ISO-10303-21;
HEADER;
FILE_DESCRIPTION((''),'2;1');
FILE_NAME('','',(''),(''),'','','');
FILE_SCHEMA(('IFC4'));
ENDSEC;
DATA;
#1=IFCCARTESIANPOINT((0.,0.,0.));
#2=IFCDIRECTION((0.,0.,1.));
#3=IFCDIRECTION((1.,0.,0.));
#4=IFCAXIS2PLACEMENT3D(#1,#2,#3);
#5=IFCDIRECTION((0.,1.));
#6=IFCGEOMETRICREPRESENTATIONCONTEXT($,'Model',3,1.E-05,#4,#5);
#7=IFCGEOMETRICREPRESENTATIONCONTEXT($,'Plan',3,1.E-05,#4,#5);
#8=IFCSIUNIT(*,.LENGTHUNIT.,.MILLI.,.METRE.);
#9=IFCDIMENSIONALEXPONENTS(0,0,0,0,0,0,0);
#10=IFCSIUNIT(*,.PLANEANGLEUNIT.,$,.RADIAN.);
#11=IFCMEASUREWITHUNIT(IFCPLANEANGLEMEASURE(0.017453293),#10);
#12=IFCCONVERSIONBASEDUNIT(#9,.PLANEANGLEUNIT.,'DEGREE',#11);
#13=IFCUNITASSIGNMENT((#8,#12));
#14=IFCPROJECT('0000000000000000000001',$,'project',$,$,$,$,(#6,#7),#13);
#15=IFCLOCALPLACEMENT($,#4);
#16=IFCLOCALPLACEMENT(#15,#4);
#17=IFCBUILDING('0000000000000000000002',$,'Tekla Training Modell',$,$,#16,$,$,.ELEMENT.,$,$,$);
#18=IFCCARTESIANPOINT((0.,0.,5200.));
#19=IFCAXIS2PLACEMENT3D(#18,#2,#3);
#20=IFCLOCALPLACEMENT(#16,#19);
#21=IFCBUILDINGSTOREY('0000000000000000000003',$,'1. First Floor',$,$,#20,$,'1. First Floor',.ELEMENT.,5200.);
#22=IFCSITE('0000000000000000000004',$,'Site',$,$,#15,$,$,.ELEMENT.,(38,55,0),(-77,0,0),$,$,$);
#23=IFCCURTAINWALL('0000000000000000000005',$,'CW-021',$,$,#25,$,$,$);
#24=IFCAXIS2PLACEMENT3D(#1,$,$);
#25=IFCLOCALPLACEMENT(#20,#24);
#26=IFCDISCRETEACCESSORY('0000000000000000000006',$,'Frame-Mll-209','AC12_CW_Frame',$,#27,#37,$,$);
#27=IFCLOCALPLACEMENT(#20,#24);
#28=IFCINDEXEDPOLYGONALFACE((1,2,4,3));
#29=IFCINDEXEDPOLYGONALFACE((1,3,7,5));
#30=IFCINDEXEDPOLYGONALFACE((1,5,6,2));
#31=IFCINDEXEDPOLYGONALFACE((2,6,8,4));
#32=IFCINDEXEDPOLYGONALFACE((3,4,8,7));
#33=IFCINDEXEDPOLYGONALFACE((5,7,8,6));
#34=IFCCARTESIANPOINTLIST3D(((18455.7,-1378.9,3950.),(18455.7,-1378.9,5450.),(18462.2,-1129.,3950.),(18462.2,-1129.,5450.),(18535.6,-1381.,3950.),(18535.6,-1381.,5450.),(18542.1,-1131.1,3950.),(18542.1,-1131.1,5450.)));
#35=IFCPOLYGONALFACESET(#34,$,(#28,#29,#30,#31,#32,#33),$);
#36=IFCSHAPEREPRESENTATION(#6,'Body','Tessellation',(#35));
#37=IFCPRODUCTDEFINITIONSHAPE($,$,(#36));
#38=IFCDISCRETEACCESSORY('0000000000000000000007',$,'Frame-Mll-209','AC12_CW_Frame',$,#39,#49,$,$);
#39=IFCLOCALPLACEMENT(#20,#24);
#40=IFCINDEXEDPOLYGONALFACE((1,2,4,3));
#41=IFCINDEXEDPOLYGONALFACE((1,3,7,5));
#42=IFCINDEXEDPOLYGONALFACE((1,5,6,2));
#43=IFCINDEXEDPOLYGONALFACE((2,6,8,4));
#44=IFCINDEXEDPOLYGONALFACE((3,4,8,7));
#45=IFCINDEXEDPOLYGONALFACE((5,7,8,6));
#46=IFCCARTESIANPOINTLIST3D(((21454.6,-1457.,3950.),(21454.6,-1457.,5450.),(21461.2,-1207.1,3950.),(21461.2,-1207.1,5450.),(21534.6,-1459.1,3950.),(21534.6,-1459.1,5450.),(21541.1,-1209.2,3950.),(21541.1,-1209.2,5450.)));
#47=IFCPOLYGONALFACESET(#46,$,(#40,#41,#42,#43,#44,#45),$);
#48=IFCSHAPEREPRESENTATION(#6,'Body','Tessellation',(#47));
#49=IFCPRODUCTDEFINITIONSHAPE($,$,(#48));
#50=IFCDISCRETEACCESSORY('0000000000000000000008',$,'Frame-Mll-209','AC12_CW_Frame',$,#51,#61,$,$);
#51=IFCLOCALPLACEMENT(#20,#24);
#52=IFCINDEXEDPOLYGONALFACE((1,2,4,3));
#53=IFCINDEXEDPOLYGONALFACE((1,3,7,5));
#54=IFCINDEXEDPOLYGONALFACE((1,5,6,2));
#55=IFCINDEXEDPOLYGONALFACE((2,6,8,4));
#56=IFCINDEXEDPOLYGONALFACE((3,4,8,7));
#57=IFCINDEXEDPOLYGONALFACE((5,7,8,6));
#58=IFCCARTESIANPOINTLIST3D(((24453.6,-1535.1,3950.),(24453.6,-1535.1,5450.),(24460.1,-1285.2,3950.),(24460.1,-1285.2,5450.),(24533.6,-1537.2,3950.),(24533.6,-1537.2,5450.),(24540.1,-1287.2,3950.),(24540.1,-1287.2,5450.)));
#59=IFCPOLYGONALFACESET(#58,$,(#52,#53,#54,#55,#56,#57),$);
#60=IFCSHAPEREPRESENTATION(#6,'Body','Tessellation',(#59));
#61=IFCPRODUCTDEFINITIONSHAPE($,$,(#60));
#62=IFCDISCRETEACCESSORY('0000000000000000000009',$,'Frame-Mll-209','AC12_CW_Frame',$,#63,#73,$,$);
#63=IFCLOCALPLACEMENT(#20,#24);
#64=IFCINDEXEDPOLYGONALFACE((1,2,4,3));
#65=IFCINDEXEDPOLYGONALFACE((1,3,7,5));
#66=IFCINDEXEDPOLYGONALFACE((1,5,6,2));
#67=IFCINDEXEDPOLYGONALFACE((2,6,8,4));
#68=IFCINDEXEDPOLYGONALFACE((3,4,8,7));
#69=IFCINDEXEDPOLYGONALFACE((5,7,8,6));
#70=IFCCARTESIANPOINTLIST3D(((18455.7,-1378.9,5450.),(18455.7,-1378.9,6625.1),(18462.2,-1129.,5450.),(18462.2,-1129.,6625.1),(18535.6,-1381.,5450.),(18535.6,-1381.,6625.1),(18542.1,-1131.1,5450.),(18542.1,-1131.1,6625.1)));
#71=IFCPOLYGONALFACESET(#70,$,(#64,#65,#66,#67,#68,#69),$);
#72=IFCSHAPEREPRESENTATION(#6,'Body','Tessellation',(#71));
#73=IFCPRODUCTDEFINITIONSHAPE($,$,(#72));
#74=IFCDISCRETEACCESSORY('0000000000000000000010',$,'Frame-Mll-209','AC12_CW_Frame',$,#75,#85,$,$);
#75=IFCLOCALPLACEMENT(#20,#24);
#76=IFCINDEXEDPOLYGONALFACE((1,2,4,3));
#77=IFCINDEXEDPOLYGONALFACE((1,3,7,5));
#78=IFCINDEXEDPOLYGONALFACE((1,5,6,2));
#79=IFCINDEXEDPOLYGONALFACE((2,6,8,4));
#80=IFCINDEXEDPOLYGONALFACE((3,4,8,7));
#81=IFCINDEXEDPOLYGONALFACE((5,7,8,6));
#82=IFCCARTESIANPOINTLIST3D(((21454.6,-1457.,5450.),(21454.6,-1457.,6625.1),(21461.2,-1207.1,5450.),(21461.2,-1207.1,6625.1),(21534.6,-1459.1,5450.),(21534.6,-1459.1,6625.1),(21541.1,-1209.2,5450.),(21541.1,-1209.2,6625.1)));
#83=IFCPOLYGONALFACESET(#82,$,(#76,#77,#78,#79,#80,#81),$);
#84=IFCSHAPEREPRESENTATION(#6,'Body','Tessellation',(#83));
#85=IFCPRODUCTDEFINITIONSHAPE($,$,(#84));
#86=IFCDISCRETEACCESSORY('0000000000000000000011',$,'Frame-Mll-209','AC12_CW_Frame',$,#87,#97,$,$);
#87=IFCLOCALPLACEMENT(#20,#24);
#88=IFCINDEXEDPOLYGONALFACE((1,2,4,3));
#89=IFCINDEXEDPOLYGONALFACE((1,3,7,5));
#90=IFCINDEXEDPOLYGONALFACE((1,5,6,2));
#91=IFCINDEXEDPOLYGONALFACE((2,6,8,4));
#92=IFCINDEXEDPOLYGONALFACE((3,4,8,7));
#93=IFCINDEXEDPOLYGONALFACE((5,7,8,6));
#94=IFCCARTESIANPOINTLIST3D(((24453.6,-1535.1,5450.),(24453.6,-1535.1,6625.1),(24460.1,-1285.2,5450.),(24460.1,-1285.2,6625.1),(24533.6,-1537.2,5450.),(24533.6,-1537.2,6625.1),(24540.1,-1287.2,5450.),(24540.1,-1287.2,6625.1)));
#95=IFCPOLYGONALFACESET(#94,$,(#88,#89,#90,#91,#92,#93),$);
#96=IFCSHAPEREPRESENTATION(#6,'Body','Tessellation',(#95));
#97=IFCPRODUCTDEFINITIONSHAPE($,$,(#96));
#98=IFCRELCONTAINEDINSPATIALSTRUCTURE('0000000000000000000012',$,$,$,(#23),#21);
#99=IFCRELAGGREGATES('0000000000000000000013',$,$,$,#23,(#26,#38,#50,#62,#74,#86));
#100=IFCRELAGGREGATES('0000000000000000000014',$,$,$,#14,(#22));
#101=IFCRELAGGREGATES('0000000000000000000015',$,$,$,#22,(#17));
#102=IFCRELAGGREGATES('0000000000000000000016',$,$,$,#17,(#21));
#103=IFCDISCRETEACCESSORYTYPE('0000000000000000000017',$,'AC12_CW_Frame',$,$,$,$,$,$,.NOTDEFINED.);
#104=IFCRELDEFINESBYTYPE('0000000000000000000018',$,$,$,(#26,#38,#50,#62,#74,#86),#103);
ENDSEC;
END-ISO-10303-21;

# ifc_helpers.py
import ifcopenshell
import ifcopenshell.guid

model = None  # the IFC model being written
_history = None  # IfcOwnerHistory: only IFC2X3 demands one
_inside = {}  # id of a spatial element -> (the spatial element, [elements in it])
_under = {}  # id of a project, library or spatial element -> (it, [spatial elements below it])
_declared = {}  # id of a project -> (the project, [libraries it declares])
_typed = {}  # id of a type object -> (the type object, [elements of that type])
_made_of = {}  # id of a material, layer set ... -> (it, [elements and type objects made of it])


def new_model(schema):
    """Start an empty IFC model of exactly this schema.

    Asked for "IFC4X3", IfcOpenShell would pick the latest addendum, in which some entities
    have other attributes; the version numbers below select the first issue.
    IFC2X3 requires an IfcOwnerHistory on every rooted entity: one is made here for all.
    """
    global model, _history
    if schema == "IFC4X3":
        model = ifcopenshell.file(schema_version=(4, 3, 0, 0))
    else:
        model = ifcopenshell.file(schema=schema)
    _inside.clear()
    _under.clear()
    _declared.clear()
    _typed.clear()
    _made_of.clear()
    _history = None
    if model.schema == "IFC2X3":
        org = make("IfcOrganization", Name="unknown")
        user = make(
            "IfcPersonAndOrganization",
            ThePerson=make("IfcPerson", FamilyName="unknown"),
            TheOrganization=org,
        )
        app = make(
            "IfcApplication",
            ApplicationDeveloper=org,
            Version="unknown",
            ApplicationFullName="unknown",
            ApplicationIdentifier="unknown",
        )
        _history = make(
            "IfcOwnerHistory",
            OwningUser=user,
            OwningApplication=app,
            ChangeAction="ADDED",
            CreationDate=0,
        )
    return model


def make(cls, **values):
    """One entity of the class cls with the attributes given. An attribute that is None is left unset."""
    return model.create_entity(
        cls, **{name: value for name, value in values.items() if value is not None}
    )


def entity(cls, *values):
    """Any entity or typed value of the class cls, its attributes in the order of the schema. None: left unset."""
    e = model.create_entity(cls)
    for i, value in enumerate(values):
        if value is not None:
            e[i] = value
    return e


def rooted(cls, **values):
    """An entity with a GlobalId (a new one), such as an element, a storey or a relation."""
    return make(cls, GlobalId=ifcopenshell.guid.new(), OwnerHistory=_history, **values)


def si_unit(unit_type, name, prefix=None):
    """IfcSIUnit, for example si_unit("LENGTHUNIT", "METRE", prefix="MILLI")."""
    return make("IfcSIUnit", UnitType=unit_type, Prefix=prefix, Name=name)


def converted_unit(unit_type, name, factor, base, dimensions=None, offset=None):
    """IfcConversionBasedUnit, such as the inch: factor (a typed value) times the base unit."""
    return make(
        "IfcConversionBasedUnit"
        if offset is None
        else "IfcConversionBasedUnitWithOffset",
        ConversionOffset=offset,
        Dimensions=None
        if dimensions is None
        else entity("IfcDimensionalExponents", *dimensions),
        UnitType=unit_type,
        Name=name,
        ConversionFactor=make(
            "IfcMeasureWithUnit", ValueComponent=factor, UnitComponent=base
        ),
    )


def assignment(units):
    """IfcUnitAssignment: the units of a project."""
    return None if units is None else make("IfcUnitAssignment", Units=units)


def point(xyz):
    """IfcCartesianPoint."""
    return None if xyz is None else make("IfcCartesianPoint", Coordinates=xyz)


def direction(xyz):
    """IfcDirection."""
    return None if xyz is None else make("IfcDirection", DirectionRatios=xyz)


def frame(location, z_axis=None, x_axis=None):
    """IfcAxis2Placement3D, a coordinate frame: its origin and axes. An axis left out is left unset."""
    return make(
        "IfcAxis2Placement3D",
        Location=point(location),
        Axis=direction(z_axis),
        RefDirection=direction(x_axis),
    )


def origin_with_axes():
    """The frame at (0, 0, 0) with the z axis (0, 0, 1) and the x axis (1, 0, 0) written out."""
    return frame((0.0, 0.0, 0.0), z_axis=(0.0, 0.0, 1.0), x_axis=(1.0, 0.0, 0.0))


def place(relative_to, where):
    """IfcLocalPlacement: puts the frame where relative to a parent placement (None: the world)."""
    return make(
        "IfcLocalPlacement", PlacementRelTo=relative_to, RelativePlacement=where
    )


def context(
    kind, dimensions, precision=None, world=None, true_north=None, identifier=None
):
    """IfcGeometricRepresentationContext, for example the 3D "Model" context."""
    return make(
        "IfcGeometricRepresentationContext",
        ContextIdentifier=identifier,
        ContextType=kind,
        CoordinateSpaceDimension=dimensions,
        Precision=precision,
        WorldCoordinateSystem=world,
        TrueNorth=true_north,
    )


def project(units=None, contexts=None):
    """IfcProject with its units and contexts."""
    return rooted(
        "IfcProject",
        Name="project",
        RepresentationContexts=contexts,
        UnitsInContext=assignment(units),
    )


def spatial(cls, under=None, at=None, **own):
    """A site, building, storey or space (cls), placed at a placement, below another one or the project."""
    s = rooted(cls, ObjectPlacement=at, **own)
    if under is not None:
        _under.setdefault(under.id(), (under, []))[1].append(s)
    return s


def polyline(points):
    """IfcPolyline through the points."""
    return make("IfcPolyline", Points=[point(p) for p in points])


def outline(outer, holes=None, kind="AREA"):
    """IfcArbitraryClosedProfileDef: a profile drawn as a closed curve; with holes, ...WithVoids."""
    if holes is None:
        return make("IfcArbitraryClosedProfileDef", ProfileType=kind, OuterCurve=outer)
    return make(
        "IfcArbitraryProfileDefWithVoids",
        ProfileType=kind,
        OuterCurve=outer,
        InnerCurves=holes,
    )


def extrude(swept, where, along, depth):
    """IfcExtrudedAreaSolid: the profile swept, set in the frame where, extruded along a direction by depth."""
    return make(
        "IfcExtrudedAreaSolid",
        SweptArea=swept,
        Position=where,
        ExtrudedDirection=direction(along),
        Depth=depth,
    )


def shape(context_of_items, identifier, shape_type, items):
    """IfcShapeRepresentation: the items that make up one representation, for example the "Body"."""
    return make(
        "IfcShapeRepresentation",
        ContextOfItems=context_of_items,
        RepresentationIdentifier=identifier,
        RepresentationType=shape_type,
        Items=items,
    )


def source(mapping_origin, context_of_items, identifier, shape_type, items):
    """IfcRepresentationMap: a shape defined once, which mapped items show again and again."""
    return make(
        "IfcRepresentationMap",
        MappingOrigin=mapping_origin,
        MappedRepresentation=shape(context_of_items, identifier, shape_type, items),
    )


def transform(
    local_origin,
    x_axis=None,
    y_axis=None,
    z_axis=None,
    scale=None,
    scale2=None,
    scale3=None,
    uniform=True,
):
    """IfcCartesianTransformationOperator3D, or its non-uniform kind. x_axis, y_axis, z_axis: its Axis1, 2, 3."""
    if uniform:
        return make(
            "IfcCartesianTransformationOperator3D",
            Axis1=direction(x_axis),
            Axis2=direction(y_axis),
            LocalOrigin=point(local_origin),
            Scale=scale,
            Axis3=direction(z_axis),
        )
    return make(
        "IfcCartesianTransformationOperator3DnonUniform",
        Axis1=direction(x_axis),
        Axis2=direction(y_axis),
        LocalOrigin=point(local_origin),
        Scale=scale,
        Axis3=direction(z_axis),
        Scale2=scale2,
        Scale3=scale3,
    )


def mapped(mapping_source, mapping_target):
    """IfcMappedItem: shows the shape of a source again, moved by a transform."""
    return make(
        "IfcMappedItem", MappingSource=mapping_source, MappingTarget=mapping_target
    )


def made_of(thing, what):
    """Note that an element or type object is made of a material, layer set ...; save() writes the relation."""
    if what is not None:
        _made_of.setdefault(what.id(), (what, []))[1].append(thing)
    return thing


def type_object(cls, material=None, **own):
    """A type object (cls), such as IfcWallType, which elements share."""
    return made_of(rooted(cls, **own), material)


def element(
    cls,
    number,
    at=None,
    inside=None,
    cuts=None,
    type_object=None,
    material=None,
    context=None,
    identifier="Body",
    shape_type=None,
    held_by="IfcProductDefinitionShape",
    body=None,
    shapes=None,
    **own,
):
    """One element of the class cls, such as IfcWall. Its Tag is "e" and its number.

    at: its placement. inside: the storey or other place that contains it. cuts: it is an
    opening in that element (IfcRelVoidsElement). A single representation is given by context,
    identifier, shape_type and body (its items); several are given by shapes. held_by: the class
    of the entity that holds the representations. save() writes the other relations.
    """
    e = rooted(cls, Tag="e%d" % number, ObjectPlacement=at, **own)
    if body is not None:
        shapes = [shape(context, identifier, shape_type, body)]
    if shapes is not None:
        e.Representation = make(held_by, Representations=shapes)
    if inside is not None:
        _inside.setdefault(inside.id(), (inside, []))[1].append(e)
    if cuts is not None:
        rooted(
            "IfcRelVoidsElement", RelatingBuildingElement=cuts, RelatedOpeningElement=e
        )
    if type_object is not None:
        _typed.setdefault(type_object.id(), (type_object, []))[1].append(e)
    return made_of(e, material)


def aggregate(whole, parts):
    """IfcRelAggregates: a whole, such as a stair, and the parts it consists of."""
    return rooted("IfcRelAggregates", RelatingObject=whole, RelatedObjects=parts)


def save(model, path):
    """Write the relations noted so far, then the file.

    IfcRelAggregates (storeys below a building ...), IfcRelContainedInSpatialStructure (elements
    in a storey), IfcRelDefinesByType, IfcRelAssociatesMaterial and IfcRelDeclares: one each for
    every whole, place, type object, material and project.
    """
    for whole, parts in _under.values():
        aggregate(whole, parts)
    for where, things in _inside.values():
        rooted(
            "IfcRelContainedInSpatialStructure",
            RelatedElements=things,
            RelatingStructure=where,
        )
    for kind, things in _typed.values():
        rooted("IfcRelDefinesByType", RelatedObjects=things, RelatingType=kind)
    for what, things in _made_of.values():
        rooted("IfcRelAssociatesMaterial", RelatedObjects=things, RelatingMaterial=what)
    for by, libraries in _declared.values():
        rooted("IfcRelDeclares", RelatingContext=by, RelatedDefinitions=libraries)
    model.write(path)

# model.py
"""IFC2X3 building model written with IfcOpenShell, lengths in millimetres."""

from ifc_helpers import new_model, entity, si_unit, converted_unit, direction, frame, origin_with_axes, place, context, project, spatial, polyline, outline, extrude, source, transform, mapped, type_object, element, aggregate, save


model = new_model("IFC2X3")

# Units and contexts
model_context = context("Model", 3, precision=1e-05, world=origin_with_axes(), true_north=direction((0.0, 1.0)))
plan_context = context("Plan", 3, precision=1e-05, world=origin_with_axes(), true_north=direction((0.0, 1.0)))
ifc_project = project(units=[si_unit("LENGTHUNIT", "METRE", prefix="MILLI"), converted_unit("PLANEANGLEUNIT", "DEGREE", entity("IfcPlaneAngleMeasure", 0.017453293), si_unit("PLANEANGLEUNIT", "RADIAN"), dimensions=[0, 0, 0, 0, 0, 0, 0])], contexts=[model_context, plan_context])

# Site, building, storey
site_placement = place(None, origin_with_axes())
site = spatial("IfcSite", under=ifc_project, at=site_placement, Name="Site", CompositionType="ELEMENT", RefLatitude=(38, 55, 0), RefLongitude=(-77, 0, 0))
building_placement = place(site_placement, origin_with_axes())
building = spatial("IfcBuilding", under=site, at=building_placement, Name="Tekla Training Modell", CompositionType="ELEMENT")
storey_placement = place(building_placement, frame((0.0, 0.0, 5200.0), z_axis=(0.0, 0.0, 1.0), x_axis=(1.0, 0.0, 0.0)))
storey = spatial("IfcBuildingStorey", under=building, at=storey_placement, Name="1. First Floor", LongName="1. First Floor", CompositionType="ELEMENT", Elevation=5200.0)

# Curtain wall, discrete accessories
curtain_wall_placement = place(storey_placement, frame((9500.0, -1095.8, -550.0), z_axis=(0.0, 0.0, 1.0), x_axis=(0.999661, -0.026022, 0.0)))
curtain_wall = element("IfcCurtainWall", 1, at=curtain_wall_placement, inside=storey, Name="CW-021")
discrete_accessory_type = type_object("IfcDiscreteAccessoryType", Name="AC12_CW_Frame")
shared_shape_1 = source(origin_with_axes(), model_context, "Body", "SweptSolid", [
    extrude(outline(polyline([(0.0, 0.0), (250.0, 0.0), (250.0, -1500.0), (0.0, -1500.0), (0.0, 0.0)])), origin_with_axes(), (0.0, 0.0, 1.0), 80.0),
])
discrete_accessory_1_placement = place(storey_placement, frame((18462.2, -1129.0, 3950.0), z_axis=(0.999661, -0.026022, 0.0), x_axis=(-0.026022, -0.999661, 0.0)))
discrete_accessory_1 = element("IfcDiscreteAccessory", 2, at=discrete_accessory_1_placement, type_object=discrete_accessory_type, Name="Frame-Mll-209", Description="AC12_CW_Frame", context=model_context, shape_type="MappedRepresentation", body=[
    mapped(shared_shape_1, transform((0.0, 0.0, 0.0), scale=1.0)),
])
discrete_accessory_2_placement = place(storey_placement, frame((21461.2, -1207.1, 3950.0), z_axis=(0.999661, -0.026022, 0.0), x_axis=(-0.026022, -0.999661, 0.0)))
discrete_accessory_2 = element("IfcDiscreteAccessory", 3, at=discrete_accessory_2_placement, type_object=discrete_accessory_type, Name="Frame-Mll-209", Description="AC12_CW_Frame", context=model_context, shape_type="MappedRepresentation", body=[
    mapped(shared_shape_1, transform((0.0, 0.0, 0.0), scale=1.0)),
])
discrete_accessory_3_placement = place(storey_placement, frame((24460.1, -1285.2, 3950.0), z_axis=(0.999661, -0.026022, 0.0), x_axis=(-0.026022, -0.999661, 0.0)))
discrete_accessory_3 = element("IfcDiscreteAccessory", 4, at=discrete_accessory_3_placement, type_object=discrete_accessory_type, Name="Frame-Mll-209", Description="AC12_CW_Frame", context=model_context, shape_type="MappedRepresentation", body=[
    mapped(shared_shape_1, transform((0.0, 0.0, 0.0), scale=1.0)),
])
shared_shape_2 = source(origin_with_axes(), model_context, "Body", "SweptSolid", [
    extrude(outline(polyline([(0.0, 0.0), (250.0, 0.0), (250.0, -1175.1), (0.0, -1175.1), (0.0, 0.0)])), origin_with_axes(), (0.0, 0.0, 1.0), 80.0),
])
discrete_accessory_4_placement = place(storey_placement, frame((18462.2, -1129.0, 5450.0), z_axis=(0.999661, -0.026022, 0.0), x_axis=(-0.026022, -0.999661, 0.0)))
discrete_accessory_4 = element("IfcDiscreteAccessory", 5, at=discrete_accessory_4_placement, type_object=discrete_accessory_type, Name="Frame-Mll-209", Description="AC12_CW_Frame", context=model_context, shape_type="MappedRepresentation", body=[
    mapped(shared_shape_2, transform((0.0, 0.0, 0.0), scale=1.0)),
])
discrete_accessory_5_placement = place(storey_placement, frame((21461.2, -1207.1, 5450.0), z_axis=(0.999661, -0.026022, 0.0), x_axis=(-0.026022, -0.999661, 0.0)))
discrete_accessory_5 = element("IfcDiscreteAccessory", 6, at=discrete_accessory_5_placement, type_object=discrete_accessory_type, Name="Frame-Mll-209", Description="AC12_CW_Frame", context=model_context, shape_type="MappedRepresentation", body=[
    mapped(shared_shape_2, transform((0.0, 0.0, 0.0), scale=1.0)),
])
discrete_accessory_6_placement = place(storey_placement, frame((24460.1, -1285.2, 5450.0), z_axis=(0.999661, -0.026022, 0.0), x_axis=(-0.026022, -0.999661, 0.0)))
discrete_accessory_6 = element("IfcDiscreteAccessory", 7, at=discrete_accessory_6_placement, type_object=discrete_accessory_type, Name="Frame-Mll-209", Description="AC12_CW_Frame", context=model_context, shape_type="MappedRepresentation", body=[
    mapped(shared_shape_2, transform((0.0, 0.0, 0.0), scale=1.0)),
])
aggregate(curtain_wall, [discrete_accessory_1, discrete_accessory_2, discrete_accessory_3, discrete_accessory_4, discrete_accessory_5, discrete_accessory_6])

save(model, "model.ifc")
